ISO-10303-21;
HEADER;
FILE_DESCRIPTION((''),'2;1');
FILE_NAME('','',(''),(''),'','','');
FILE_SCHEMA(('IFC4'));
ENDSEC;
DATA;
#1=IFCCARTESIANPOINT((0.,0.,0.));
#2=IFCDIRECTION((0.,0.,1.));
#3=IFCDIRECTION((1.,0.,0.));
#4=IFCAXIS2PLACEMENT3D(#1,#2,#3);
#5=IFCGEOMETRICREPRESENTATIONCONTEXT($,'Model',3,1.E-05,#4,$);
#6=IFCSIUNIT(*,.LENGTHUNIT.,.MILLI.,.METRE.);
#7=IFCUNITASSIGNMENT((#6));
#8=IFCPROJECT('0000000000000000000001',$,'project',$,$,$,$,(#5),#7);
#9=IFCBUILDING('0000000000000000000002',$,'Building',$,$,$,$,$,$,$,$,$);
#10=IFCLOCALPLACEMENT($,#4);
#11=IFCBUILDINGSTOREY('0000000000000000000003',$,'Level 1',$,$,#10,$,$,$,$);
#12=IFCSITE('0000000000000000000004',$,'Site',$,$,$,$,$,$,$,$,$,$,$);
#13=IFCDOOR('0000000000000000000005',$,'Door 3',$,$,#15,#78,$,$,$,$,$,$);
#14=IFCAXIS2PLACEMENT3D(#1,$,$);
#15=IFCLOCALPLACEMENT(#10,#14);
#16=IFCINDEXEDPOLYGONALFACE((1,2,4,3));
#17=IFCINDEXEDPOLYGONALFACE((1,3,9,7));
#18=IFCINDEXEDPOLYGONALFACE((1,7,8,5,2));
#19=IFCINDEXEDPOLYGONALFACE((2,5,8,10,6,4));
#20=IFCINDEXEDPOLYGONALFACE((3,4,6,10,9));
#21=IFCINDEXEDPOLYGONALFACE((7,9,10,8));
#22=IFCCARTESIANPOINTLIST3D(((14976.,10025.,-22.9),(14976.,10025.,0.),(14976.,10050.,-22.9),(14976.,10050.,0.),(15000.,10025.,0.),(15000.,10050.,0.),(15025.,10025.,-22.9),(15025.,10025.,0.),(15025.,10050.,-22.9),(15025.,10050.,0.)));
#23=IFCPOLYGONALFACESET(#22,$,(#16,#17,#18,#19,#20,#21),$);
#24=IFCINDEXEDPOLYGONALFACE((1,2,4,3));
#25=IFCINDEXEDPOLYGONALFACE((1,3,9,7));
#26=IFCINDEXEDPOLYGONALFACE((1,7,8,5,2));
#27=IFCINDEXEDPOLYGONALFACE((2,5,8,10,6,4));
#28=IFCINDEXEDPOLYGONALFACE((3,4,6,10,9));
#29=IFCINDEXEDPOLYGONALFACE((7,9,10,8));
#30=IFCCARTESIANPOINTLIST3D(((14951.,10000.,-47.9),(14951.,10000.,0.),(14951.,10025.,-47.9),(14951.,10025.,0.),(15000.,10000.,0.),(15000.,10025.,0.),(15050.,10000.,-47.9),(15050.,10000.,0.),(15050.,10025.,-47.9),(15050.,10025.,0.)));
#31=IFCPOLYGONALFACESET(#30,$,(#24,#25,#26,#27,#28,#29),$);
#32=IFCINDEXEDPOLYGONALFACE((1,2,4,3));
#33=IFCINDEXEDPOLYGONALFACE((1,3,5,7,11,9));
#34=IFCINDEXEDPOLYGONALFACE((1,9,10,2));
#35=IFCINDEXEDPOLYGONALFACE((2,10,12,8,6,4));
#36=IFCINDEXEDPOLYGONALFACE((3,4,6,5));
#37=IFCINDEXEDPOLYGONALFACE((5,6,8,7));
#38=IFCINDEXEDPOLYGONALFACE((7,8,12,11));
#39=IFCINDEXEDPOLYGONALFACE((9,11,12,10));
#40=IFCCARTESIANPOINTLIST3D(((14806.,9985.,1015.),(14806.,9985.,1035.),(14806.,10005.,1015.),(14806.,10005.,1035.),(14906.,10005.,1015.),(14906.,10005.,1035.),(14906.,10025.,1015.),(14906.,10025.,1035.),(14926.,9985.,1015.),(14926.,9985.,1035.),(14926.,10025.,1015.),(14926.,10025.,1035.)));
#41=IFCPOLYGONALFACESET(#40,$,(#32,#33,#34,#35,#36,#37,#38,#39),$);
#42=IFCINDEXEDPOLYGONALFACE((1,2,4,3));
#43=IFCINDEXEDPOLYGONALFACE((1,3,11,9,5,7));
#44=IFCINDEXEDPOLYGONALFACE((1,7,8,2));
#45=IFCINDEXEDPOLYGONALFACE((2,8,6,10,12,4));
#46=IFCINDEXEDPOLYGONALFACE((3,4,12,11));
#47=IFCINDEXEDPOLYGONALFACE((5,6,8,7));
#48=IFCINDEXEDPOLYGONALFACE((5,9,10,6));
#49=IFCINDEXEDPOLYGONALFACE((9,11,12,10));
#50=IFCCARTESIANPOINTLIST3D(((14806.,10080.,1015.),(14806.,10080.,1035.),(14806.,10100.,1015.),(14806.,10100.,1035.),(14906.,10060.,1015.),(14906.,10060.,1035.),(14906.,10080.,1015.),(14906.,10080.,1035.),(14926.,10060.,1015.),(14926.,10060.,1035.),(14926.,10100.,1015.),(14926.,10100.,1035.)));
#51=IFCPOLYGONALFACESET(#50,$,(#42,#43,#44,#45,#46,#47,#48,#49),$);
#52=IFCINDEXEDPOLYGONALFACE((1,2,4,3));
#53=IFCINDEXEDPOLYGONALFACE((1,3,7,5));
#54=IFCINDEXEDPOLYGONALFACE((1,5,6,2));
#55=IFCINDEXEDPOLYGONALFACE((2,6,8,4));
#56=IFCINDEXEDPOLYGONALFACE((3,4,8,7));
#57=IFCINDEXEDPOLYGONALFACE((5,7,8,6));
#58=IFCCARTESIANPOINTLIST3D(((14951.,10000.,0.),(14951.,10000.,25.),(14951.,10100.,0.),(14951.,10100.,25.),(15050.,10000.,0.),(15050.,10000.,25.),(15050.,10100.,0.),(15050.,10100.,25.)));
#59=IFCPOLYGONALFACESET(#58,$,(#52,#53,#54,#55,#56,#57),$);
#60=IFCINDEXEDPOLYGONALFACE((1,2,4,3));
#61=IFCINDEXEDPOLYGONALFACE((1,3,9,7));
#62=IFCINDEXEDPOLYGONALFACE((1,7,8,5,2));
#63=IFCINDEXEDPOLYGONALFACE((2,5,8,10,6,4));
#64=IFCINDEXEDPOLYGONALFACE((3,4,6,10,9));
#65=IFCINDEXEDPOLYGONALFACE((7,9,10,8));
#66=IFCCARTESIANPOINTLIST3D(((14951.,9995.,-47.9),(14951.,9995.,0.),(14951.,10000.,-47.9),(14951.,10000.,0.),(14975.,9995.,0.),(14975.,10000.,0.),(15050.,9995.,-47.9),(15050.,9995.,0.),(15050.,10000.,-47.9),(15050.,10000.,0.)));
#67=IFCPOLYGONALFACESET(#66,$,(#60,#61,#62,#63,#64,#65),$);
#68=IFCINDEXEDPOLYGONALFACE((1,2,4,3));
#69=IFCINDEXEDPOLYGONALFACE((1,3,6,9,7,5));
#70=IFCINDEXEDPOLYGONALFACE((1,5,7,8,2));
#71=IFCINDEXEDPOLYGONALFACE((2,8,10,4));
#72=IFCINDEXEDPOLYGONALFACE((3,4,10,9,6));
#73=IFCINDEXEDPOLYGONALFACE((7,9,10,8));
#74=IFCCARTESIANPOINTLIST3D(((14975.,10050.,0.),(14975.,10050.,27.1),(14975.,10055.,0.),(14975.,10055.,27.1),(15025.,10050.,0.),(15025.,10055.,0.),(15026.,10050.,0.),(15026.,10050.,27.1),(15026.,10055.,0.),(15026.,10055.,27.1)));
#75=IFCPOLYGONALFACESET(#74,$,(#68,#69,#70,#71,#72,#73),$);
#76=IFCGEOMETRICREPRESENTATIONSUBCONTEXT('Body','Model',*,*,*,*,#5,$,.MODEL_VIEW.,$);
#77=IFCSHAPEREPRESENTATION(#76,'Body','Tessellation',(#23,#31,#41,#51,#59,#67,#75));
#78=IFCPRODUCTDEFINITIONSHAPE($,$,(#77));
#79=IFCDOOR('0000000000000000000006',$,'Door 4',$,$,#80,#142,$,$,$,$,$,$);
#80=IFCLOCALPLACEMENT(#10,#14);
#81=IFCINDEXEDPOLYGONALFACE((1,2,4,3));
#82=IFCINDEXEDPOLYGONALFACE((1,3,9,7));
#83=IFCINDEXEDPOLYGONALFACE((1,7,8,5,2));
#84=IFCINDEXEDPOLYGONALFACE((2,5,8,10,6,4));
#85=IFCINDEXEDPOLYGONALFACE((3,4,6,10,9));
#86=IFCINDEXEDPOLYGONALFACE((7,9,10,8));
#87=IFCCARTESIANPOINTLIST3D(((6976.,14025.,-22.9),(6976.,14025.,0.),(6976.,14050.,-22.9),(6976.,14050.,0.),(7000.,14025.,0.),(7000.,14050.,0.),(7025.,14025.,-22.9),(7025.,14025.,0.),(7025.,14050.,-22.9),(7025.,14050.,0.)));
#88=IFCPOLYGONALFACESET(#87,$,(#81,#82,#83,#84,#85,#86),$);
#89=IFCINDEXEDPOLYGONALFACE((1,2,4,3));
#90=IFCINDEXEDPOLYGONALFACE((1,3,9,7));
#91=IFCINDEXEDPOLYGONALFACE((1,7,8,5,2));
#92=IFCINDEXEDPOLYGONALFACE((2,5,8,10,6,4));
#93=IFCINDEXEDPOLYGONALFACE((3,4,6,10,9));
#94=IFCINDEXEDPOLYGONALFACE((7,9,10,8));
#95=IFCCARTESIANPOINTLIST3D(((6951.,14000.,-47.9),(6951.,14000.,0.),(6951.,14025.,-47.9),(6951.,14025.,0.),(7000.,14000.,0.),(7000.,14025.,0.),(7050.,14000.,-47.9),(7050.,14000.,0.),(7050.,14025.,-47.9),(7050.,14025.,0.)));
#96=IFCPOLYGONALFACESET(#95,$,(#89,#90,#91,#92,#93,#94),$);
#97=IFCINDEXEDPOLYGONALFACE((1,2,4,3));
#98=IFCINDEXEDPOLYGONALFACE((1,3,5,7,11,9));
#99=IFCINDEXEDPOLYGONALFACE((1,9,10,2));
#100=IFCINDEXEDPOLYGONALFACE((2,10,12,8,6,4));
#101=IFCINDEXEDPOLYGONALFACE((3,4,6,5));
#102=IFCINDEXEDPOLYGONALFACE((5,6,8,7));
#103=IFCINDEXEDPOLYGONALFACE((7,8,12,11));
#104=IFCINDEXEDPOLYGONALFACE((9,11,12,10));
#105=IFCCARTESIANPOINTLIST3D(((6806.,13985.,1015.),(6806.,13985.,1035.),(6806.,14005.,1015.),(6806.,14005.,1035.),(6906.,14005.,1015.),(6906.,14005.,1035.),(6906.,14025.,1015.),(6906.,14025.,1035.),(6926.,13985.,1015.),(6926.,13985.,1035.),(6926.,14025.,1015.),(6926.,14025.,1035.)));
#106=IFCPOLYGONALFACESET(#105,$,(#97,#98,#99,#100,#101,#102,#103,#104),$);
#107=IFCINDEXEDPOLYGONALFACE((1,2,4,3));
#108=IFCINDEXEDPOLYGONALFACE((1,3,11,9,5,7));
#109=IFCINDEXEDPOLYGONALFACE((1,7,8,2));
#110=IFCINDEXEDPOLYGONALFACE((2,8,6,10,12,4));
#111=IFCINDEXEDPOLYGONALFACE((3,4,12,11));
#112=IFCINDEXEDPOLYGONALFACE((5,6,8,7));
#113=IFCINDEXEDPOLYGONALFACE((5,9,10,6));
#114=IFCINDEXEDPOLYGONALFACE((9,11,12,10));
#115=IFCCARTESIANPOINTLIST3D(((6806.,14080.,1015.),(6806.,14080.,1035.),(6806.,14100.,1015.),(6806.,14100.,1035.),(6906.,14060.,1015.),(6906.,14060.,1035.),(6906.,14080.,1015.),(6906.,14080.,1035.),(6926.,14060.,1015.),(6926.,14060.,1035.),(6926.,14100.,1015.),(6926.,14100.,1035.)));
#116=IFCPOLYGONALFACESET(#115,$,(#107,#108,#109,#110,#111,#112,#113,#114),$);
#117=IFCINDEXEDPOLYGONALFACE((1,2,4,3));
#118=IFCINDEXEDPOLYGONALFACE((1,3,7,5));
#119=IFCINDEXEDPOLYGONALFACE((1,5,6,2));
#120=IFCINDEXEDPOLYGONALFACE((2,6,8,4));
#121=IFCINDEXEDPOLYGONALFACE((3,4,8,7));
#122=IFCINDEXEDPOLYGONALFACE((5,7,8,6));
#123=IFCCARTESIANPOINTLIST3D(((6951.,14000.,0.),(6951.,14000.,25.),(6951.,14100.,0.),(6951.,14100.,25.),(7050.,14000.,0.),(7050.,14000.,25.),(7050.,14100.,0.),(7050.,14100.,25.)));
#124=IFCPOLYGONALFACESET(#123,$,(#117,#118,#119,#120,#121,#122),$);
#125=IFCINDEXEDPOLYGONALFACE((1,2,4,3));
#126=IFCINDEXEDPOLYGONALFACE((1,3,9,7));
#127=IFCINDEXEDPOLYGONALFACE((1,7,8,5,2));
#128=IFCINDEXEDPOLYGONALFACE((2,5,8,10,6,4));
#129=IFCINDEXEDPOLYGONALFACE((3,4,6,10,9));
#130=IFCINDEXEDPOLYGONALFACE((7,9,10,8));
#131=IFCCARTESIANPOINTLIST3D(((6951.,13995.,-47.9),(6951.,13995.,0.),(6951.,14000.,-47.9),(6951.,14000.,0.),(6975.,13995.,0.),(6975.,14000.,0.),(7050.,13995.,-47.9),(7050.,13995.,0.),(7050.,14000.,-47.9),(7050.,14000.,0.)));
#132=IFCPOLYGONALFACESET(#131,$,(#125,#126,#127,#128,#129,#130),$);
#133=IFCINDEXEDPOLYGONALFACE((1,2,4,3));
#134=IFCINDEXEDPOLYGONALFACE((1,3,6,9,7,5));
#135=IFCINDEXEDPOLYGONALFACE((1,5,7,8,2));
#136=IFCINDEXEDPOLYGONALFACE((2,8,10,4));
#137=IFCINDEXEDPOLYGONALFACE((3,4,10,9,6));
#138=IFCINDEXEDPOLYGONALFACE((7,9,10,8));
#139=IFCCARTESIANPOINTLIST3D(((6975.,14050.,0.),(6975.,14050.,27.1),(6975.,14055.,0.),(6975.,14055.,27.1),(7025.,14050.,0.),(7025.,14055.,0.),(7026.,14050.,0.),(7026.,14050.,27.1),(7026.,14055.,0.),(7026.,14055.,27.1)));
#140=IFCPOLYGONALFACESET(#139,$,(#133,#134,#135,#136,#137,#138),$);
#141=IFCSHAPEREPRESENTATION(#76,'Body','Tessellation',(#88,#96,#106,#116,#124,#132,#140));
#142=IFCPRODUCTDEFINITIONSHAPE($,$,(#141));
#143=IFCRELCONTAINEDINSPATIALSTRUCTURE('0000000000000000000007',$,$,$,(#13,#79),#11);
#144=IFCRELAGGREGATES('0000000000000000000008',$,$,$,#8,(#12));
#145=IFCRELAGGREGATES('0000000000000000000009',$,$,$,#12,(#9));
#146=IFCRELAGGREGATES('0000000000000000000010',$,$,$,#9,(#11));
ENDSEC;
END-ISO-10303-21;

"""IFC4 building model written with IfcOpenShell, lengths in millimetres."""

from ifc_helpers import new_model, si_unit, frame, origin_with_axes, place, context, subcontext, project, spatial, line, indexed_curve, outline, extrude, element, save


model = new_model("IFC4")

# Units and contexts
model_context = context("Model", 3, precision=1e-05, world=origin_with_axes())
body_context = subcontext(model_context, "Body", "Model", "MODEL_VIEW")
ifc_project = project(units=[si_unit("LENGTHUNIT", "METRE", prefix="MILLI")], contexts=[model_context])

# Site, building, storey
site = spatial("IfcSite", under=ifc_project, Name="Site")
building = spatial("IfcBuilding", under=site, Name="Building")
storey_placement = place(None, origin_with_axes())
storey = spatial("IfcBuildingStorey", under=building, at=storey_placement, Name="Level 1")

# Doors
door_1_placement = place(storey_placement, frame((15000.0, 10000.0, 0.0), z_axis=(0.0, 0.0, 1.0), x_axis=(1.0, 0.0, 0.0)))
element("IfcDoor", 1, at=door_1_placement, inside=storey, Name="Door 3", context=body_context, shape_type="SweptSolid", body=[
    extrude(outline(indexed_curve([(0.0, 0.0), (0.0, 2.1), (1.0, 2.1), (1.0, 0.0), (-24.0, 0.0), (-24.0, -22.9), (25.0, -22.9), (25.0, 0.0)], segments=[line(1, 2, 3, 4, 5, 6, 7, 8, 1)])), frame((0.0, 25.0, 0.0), z_axis=(0.0, -1.0, 0.0), x_axis=(1.0, 0.0, 0.0)), (0.0, 0.0, -1.0), 25.0),
    extrude(outline(indexed_curve([(0.0, 0.0), (0.0, 2.1), (1.0, 2.1), (1.0, 0.0), (-49.0, 0.0), (-49.0, -47.9), (50.0, -47.9), (50.0, 0.0)], segments=[line(1, 2, 3, 4, 5, 6, 7, 8, 1)])), frame((0.0, 0.0, 0.0), z_axis=(0.0, -1.0, 0.0), x_axis=(1.0, 0.0, 0.0)), (0.0, 0.0, -1.0), 25.0),
    extrude(outline(indexed_curve([(0.0, 0.0), (-49.0, 0.0), (-49.0, 35.0), (0.0, 35.0)], segments=[line(1, 2, 3, 4, 1)])), frame((25.0, 25.0, 25.0), z_axis=(0.0, 0.0, 1.0), x_axis=(1.0, 0.0, 0.0)), (0.0, 0.0, 1.0), -47.9),
    extrude(outline(indexed_curve([(0.0, 0.0), (0.0, -40.0), (-120.0, -40.0), (-120.0, -20.0), (-20.0, -20.0), (-20.0, 0.0)], segments=[line(1, 2, 3, 4, 5, 6, 1)])), frame((-74.0, 25.0, 1015.0), z_axis=(0.0, 0.0, 1.0), x_axis=(1.0, 0.0, 0.0)), (0.0, 0.0, 1.0), 20.0),
    extrude(outline(indexed_curve([(0.0, 0.0), (0.0, 40.0), (-120.0, 40.0), (-120.0, 20.0), (-20.0, 20.0), (-20.0, 0.0)], segments=[line(1, 2, 3, 4, 5, 6, 1)])), frame((-74.0, 60.0, 1015.0), z_axis=(0.0, 0.0, 1.0), x_axis=(1.0, 0.0, 0.0)), (0.0, 0.0, 1.0), 20.0),
    extrude(outline(indexed_curve([(0.0, 0.0), (-99.0, 0.0), (-99.0, 100.0), (0.0, 100.0)], segments=[line(1, 2, 3, 4, 1)])), frame((50.0, 0.0, 0.0), z_axis=(0.0, 0.0, 1.0), x_axis=(1.0, 0.0, 0.0)), (0.0, 0.0, 1.0), 25.0),
    extrude(outline(indexed_curve([(0.0, 0.0), (0.0, 27.1), (51.0, 27.1), (51.0, 0.0), (-24.0, 0.0), (-24.0, -47.9), (75.0, -47.9), (75.0, 0.0)], segments=[line(1, 2, 3, 4, 5, 6, 7, 8, 1)])), frame((-25.0, -5.0, 0.0), z_axis=(0.0, -1.0, 0.0), x_axis=(1.0, 0.0, 0.0)), (0.0, 0.0, -1.0), 5.0),
    extrude(outline(indexed_curve([(0.0, 0.0), (0.0, 27.1), (51.0, 27.1), (51.0, 0.0), (1.0, 0.0), (1.0, -22.9), (50.0, -22.9), (50.0, 0.0)], segments=[line(1, 2, 3, 4, 5, 6, 7, 8, 1)])), frame((-25.0, 50.0, 0.0), z_axis=(0.0, -1.0, 0.0), x_axis=(1.0, 0.0, 0.0)), (0.0, 0.0, -1.0), 5.0),
])
door_2_placement = place(storey_placement, frame((7000.0, 14000.0, 0.0), z_axis=(0.0, 0.0, 1.0), x_axis=(1.0, 0.0, 0.0)))
element("IfcDoor", 2, at=door_2_placement, inside=storey, Name="Door 4", context=body_context, shape_type="SweptSolid", body=[
    extrude(outline(indexed_curve([(0.0, 0.0), (0.0, 2.1), (1.0, 2.1), (1.0, 0.0), (-24.0, 0.0), (-24.0, -22.9), (25.0, -22.9), (25.0, 0.0)], segments=[line(1, 2, 3, 4, 5, 6, 7, 8, 1)])), frame((0.0, 25.0, 0.0), z_axis=(0.0, -1.0, 0.0), x_axis=(1.0, 0.0, 0.0)), (0.0, 0.0, -1.0), 25.0),
    extrude(outline(indexed_curve([(0.0, 0.0), (0.0, 2.1), (1.0, 2.1), (1.0, 0.0), (-49.0, 0.0), (-49.0, -47.9), (50.0, -47.9), (50.0, 0.0)], segments=[line(1, 2, 3, 4, 5, 6, 7, 8, 1)])), frame((0.0, 0.0, 0.0), z_axis=(0.0, -1.0, 0.0), x_axis=(1.0, 0.0, 0.0)), (0.0, 0.0, -1.0), 25.0),
    extrude(outline(indexed_curve([(0.0, 0.0), (-49.0, 0.0), (-49.0, 35.0), (0.0, 35.0)], segments=[line(1, 2, 3, 4, 1)])), frame((25.0, 25.0, 25.0), z_axis=(0.0, 0.0, 1.0), x_axis=(1.0, 0.0, 0.0)), (0.0, 0.0, 1.0), -47.9),
    extrude(outline(indexed_curve([(0.0, 0.0), (0.0, -40.0), (-120.0, -40.0), (-120.0, -20.0), (-20.0, -20.0), (-20.0, 0.0)], segments=[line(1, 2, 3, 4, 5, 6, 1)])), frame((-74.0, 25.0, 1015.0), z_axis=(0.0, 0.0, 1.0), x_axis=(1.0, 0.0, 0.0)), (0.0, 0.0, 1.0), 20.0),
    extrude(outline(indexed_curve([(0.0, 0.0), (0.0, 40.0), (-120.0, 40.0), (-120.0, 20.0), (-20.0, 20.0), (-20.0, 0.0)], segments=[line(1, 2, 3, 4, 5, 6, 1)])), frame((-74.0, 60.0, 1015.0), z_axis=(0.0, 0.0, 1.0), x_axis=(1.0, 0.0, 0.0)), (0.0, 0.0, 1.0), 20.0),
    extrude(outline(indexed_curve([(0.0, 0.0), (-99.0, 0.0), (-99.0, 100.0), (0.0, 100.0)], segments=[line(1, 2, 3, 4, 1)])), frame((50.0, 0.0, 0.0), z_axis=(0.0, 0.0, 1.0), x_axis=(1.0, 0.0, 0.0)), (0.0, 0.0, 1.0), 25.0),
    extrude(outline(indexed_curve([(0.0, 0.0), (0.0, 27.1), (51.0, 27.1), (51.0, 0.0), (-24.0, 0.0), (-24.0, -47.9), (75.0, -47.9), (75.0, 0.0)], segments=[line(1, 2, 3, 4, 5, 6, 7, 8, 1)])), frame((-25.0, -5.0, 0.0), z_axis=(0.0, -1.0, 0.0), x_axis=(1.0, 0.0, 0.0)), (0.0, 0.0, -1.0), 5.0),
    extrude(outline(indexed_curve([(0.0, 0.0), (0.0, 27.1), (51.0, 27.1), (51.0, 0.0), (1.0, 0.0), (1.0, -22.9), (50.0, -22.9), (50.0, 0.0)], segments=[line(1, 2, 3, 4, 5, 6, 7, 8, 1)])), frame((-25.0, 50.0, 0.0), z_axis=(0.0, -1.0, 0.0), x_axis=(1.0, 0.0, 0.0)), (0.0, 0.0, -1.0), 5.0),
])

save(model, "model.ifc")
